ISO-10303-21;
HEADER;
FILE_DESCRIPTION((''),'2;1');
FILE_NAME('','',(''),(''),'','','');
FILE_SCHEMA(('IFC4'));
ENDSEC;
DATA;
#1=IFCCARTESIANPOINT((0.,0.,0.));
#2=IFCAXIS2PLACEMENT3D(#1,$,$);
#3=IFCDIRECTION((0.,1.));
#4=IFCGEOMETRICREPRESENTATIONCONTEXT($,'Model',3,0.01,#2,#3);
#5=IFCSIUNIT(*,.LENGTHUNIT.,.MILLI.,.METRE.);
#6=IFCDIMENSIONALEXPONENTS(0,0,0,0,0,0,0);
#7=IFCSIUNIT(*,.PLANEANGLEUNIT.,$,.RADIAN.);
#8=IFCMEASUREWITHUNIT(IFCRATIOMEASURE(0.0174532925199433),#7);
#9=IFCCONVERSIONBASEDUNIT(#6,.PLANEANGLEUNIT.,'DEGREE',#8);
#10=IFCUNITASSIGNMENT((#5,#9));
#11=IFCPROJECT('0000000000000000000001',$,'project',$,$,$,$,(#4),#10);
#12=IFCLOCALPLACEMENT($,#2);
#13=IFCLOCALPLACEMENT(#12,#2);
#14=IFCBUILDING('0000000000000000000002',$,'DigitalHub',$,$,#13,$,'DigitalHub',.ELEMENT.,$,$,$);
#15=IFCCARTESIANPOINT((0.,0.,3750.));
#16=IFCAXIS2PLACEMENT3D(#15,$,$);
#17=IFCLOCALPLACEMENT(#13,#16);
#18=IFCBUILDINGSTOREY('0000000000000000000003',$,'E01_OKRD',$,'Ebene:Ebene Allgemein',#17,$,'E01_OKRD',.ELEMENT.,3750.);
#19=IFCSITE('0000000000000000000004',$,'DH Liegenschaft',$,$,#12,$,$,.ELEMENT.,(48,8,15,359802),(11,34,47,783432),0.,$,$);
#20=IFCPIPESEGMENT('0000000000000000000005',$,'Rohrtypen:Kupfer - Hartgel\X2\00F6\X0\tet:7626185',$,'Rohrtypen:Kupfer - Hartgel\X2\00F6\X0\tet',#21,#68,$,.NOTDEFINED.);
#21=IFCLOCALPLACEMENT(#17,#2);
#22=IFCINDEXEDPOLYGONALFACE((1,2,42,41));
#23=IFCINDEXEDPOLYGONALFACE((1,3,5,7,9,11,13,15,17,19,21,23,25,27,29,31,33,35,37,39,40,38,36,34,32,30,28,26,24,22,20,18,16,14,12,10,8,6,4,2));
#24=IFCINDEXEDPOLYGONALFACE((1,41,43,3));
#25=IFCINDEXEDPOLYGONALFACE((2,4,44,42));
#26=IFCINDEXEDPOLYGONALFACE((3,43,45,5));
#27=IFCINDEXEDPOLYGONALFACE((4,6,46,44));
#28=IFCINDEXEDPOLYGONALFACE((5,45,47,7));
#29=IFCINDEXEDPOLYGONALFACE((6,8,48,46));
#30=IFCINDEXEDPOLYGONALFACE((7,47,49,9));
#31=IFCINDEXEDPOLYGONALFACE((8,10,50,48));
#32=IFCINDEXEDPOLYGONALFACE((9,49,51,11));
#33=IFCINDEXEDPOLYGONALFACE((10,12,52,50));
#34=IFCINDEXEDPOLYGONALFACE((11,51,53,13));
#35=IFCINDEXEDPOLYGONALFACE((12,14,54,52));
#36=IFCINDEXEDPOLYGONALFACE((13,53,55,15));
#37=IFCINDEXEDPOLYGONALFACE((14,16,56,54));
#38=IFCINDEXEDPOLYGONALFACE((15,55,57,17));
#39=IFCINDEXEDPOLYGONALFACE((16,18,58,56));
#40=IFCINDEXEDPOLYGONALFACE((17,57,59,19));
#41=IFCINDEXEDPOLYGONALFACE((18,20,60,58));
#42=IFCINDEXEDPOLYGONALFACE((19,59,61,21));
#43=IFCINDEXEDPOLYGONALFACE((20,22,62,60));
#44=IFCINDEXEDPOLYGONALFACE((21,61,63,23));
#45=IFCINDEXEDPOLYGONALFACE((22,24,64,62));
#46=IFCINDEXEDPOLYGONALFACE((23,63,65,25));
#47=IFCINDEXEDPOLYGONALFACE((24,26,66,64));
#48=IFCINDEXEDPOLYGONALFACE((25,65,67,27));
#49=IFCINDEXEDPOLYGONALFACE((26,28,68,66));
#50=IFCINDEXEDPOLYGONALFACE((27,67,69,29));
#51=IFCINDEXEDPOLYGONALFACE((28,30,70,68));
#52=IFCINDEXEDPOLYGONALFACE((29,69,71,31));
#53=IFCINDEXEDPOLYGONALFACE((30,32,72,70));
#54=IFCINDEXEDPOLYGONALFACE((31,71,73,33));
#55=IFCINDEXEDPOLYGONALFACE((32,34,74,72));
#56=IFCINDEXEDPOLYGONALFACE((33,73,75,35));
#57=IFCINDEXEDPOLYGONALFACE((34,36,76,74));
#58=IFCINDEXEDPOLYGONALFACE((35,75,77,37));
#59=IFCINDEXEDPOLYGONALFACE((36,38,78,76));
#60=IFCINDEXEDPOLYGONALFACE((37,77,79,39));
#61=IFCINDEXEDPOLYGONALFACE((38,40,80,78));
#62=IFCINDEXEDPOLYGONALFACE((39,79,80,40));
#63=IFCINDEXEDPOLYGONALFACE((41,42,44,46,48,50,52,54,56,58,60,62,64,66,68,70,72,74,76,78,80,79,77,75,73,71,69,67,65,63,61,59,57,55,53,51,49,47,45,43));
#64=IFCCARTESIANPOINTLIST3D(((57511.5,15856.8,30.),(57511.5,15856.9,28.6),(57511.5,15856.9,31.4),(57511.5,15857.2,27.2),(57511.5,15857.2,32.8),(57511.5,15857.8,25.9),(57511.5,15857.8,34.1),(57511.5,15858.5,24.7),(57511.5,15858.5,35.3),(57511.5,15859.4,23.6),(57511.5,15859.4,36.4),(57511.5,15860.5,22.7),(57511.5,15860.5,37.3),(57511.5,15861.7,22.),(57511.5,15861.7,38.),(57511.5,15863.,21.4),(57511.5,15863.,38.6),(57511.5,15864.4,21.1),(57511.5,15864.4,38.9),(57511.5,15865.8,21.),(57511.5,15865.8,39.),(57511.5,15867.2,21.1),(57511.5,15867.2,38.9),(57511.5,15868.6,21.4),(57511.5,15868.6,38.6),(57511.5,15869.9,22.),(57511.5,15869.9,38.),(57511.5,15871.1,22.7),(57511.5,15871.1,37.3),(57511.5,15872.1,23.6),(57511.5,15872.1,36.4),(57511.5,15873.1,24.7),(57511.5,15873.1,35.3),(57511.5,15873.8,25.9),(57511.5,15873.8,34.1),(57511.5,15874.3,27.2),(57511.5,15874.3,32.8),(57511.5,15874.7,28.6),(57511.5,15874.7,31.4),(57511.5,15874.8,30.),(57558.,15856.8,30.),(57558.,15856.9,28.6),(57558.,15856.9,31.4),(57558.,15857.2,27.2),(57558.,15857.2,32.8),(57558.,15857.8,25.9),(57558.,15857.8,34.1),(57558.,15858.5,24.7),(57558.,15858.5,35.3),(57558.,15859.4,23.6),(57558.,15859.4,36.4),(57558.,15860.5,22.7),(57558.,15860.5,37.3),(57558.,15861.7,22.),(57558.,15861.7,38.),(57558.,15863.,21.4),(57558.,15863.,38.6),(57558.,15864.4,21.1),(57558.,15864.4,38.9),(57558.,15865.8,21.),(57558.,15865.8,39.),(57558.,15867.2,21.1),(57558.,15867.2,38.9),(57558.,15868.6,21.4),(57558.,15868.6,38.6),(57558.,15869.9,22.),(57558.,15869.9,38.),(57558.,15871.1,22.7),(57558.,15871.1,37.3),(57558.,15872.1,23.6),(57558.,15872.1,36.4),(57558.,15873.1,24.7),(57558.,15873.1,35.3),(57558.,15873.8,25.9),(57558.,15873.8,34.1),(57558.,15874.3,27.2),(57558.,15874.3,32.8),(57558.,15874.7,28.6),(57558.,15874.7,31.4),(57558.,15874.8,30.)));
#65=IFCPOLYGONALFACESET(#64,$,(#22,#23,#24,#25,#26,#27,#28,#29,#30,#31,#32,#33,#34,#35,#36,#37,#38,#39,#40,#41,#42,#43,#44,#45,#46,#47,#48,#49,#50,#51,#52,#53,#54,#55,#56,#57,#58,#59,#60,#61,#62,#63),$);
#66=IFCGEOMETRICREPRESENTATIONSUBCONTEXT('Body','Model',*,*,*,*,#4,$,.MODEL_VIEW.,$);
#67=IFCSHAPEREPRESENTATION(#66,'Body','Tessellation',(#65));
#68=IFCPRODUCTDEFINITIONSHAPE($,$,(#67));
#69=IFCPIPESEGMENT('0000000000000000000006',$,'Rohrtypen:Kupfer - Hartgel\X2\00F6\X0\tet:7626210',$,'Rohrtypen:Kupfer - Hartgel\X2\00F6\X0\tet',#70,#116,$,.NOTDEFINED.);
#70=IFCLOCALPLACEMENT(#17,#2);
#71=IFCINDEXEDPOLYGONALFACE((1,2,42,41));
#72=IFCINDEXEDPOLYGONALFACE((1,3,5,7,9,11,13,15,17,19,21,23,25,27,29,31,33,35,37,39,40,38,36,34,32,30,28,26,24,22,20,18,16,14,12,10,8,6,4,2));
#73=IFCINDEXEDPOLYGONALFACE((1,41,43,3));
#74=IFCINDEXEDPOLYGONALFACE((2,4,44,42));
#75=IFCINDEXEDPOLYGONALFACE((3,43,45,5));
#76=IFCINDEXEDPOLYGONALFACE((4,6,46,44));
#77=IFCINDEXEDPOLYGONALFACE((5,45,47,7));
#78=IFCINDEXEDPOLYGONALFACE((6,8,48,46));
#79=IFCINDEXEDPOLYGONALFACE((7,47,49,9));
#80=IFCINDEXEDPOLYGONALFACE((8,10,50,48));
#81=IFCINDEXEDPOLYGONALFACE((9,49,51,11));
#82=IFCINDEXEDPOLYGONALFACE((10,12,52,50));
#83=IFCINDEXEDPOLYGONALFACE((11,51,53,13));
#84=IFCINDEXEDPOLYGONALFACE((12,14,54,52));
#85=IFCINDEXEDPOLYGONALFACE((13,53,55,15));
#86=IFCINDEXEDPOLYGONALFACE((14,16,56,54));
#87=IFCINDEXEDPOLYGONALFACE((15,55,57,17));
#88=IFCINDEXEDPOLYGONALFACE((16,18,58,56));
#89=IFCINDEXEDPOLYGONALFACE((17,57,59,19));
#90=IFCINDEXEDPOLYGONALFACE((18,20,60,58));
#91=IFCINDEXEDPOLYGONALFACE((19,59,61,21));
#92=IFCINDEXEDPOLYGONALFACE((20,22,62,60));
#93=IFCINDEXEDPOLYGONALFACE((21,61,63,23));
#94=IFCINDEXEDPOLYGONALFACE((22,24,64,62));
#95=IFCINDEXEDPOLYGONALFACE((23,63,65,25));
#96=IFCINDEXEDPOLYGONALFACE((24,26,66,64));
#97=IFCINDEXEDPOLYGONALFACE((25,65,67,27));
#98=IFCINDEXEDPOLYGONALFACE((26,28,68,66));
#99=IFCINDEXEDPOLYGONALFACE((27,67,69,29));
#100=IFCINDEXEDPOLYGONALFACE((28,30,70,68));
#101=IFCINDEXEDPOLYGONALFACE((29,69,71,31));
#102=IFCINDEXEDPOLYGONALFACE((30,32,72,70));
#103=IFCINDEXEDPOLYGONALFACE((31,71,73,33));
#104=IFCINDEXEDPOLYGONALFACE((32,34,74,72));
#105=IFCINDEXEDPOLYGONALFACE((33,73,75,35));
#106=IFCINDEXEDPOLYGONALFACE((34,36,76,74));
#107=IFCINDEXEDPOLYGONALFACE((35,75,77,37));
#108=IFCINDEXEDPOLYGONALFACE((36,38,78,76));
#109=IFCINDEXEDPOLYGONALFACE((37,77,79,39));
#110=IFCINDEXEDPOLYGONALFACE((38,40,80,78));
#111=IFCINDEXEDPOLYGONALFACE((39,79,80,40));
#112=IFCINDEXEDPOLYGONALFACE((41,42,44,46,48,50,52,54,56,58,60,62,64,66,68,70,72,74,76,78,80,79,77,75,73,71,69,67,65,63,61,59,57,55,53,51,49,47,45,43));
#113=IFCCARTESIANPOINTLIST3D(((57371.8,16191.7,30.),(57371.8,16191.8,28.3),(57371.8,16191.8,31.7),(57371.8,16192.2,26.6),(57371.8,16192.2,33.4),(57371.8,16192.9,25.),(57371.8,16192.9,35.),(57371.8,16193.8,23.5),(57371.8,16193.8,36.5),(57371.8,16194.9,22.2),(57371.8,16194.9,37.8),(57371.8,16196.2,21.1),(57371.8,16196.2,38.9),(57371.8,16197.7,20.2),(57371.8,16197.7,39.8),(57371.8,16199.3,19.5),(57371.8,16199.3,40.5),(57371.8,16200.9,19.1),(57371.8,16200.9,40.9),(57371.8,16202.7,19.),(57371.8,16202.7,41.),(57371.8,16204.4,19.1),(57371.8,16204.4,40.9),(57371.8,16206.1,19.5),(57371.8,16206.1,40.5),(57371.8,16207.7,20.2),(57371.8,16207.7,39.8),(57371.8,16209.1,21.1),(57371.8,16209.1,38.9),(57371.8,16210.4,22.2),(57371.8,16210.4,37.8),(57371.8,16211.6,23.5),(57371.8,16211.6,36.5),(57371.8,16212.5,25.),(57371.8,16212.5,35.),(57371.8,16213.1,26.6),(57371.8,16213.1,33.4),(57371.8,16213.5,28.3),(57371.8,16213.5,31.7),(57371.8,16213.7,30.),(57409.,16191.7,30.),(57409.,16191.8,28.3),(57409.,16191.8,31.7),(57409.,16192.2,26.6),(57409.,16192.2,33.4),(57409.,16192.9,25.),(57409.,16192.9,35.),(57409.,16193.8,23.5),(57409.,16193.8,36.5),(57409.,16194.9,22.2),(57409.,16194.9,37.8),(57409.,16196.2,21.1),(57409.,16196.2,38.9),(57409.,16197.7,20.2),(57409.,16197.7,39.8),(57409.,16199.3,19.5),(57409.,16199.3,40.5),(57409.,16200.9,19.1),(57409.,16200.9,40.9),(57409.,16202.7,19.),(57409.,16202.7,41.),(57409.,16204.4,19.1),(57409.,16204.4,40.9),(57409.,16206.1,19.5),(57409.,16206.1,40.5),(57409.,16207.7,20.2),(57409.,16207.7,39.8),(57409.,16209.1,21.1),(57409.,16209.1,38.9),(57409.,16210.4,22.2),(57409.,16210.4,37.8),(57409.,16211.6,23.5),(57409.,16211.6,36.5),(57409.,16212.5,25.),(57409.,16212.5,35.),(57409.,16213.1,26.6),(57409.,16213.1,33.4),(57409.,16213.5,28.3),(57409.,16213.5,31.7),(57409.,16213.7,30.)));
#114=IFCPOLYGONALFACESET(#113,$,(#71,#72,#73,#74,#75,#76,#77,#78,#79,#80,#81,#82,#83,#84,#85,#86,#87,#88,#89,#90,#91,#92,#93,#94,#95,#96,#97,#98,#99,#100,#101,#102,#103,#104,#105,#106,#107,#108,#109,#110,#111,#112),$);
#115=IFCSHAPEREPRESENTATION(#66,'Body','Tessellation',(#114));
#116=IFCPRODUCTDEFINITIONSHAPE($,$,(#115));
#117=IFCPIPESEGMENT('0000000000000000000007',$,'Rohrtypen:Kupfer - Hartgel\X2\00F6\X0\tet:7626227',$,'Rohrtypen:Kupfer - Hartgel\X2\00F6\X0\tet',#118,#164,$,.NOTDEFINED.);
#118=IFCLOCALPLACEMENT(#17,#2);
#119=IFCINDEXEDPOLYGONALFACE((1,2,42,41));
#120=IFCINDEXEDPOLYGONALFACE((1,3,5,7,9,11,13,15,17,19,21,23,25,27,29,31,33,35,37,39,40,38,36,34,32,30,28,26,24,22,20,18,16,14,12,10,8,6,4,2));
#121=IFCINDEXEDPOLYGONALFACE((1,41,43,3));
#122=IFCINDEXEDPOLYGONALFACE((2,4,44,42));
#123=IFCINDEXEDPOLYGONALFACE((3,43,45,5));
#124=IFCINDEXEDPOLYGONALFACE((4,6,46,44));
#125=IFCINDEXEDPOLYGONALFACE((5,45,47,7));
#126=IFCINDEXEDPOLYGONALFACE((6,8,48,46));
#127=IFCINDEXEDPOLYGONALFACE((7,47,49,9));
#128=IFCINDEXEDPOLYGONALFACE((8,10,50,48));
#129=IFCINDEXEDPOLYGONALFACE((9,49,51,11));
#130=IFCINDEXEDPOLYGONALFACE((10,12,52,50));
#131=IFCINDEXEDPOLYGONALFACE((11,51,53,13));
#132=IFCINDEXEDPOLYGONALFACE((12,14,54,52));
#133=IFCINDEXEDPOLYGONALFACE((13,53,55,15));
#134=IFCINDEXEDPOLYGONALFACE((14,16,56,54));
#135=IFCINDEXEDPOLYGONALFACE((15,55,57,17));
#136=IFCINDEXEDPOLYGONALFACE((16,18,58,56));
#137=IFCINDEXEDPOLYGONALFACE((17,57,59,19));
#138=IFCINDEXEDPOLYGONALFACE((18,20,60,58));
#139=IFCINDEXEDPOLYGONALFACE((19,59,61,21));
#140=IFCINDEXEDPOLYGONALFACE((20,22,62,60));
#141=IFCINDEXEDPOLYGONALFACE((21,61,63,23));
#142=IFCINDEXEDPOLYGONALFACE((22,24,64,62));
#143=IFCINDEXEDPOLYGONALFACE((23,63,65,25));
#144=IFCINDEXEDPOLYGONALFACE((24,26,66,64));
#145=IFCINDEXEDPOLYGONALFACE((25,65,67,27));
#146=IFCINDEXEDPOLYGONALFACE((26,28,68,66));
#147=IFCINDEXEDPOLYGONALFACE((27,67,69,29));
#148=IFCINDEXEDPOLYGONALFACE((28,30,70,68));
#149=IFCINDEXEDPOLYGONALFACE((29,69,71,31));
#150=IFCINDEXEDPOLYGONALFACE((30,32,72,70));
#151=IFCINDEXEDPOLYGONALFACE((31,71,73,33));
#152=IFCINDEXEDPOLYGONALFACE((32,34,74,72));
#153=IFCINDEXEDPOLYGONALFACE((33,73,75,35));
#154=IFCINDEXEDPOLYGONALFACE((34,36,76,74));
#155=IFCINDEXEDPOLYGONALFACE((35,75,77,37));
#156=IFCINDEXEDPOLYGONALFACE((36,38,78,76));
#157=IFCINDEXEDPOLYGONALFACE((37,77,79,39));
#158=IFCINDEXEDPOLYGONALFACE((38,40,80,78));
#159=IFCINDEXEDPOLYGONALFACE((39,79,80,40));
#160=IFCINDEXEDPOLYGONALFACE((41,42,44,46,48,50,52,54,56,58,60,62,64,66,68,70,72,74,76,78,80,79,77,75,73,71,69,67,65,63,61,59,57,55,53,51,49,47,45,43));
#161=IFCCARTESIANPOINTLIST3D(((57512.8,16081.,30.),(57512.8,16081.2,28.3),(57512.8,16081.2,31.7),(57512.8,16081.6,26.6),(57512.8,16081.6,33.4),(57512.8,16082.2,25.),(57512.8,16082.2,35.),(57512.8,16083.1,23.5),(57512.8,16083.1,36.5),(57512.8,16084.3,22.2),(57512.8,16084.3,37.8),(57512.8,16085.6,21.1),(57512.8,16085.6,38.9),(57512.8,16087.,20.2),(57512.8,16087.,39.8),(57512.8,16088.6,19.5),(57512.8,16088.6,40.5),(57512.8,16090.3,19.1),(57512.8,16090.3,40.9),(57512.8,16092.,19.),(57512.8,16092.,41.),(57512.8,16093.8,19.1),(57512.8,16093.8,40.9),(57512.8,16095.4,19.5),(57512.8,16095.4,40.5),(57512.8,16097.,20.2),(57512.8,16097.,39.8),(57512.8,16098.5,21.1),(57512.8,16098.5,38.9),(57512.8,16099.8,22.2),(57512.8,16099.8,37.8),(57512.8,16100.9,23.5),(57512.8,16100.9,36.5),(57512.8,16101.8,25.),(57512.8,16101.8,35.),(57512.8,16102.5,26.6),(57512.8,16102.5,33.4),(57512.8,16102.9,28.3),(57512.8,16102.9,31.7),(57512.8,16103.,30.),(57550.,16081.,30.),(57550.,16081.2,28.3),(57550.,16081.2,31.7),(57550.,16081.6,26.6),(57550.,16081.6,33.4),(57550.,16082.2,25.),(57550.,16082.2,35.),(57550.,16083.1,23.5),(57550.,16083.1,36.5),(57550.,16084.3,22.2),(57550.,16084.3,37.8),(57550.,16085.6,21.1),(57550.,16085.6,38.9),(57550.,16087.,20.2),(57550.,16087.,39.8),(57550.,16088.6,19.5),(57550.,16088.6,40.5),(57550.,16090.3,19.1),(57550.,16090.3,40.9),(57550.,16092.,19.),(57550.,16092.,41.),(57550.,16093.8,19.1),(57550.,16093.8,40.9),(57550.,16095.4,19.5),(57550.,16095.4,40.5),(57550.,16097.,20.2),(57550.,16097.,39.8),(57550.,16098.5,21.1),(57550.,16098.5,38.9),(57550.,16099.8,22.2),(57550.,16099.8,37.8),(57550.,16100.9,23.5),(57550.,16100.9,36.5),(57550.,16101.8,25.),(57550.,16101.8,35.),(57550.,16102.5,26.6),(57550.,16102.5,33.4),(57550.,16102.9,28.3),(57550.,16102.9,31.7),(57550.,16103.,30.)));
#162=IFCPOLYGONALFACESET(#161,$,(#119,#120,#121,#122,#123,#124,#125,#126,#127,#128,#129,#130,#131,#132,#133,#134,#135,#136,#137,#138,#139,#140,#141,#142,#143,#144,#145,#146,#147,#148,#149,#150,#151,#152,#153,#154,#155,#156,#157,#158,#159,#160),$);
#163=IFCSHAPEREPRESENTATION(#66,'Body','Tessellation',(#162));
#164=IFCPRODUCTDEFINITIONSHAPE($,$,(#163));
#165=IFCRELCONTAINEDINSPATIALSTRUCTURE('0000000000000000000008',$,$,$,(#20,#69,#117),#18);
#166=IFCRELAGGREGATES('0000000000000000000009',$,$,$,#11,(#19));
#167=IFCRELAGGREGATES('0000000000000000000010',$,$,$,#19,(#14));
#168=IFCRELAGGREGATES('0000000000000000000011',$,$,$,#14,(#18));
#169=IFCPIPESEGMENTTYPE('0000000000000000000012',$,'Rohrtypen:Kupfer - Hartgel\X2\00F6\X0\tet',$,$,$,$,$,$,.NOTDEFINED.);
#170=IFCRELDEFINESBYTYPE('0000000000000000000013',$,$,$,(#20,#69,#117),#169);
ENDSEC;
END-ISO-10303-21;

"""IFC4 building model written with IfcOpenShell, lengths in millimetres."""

from ifc_helpers import new_model, entity, si_unit, converted_unit, direction, frame, origin, place, context, subcontext, project, spatial, indexed_curve, outline, extrude, type_object, element, save


model = new_model("IFC4")

# Units and contexts
model_context = context("Model", 3, precision=0.01, world=origin(), true_north=direction((0.0, 1.0)))
body_context = subcontext(model_context, "Body", "Model", "MODEL_VIEW")
ifc_project = project(units=[si_unit("LENGTHUNIT", "METRE", prefix="MILLI"), converted_unit("PLANEANGLEUNIT", "DEGREE", entity("IfcRatioMeasure", 0.0174532925199433), si_unit("PLANEANGLEUNIT", "RADIAN"), dimensions=[0, 0, 0, 0, 0, 0, 0])], contexts=[model_context])

# Site, building, storey
site_placement = place(None, origin())
site = spatial("IfcSite", under=ifc_project, at=site_placement, Name="DH Liegenschaft", CompositionType="ELEMENT", RefLatitude=(48, 8, 15, 359802), RefLongitude=(11, 34, 47, 783432), RefElevation=0.0)
building_placement = place(site_placement, origin())
building = spatial("IfcBuilding", under=site, at=building_placement, Name="DigitalHub", LongName="DigitalHub", CompositionType="ELEMENT")
storey_placement = place(building_placement, frame((0.0, 0.0, 3750.0)))
storey = spatial("IfcBuildingStorey", under=building, at=storey_placement, Name="E01_OKRD", ObjectType="Ebene:Ebene Allgemein", LongName="E01_OKRD", CompositionType="ELEMENT", Elevation=3750.0)

# Pipe segments
pipe_segment_type = type_object("IfcPipeSegmentType", Name="Rohrtypen:Kupfer - Hartgelötet", PredefinedType="NOTDEFINED")
pipe_segment_1_placement = place(storey_placement, frame((57511.5, 15855.2, 19.4)))
element("IfcPipeSegment", 1, at=pipe_segment_1_placement, inside=storey, type_object=pipe_segment_type, Name="Rohrtypen:Kupfer - Hartgelötet:7626185", ObjectType="Rohrtypen:Kupfer - Hartgelötet", PredefinedType="NOTDEFINED", context=body_context, shape_type="SweptSolid", body=[
    extrude(outline(indexed_curve([(9.0, 0.0), (8.9, 1.4), (8.6, 2.8), (8.0, 4.1), (7.3, 5.3), (6.4, 6.4), (5.3, 7.3), (4.1, 8.0), (2.8, 8.6), (1.4, 8.9), (0.0, 9.0), (-1.4, 8.9), (-2.8, 8.6), (-4.1, 8.0), (-5.3, 7.3), (-6.4, 6.4), (-7.3, 5.3), (-8.0, 4.1), (-8.6, 2.8), (-8.9, 1.4), (-9.0, 0.0), (-8.9, -1.4), (-8.6, -2.8), (-8.0, -4.1), (-7.3, -5.3), (-6.4, -6.4), (-5.3, -7.3), (-4.1, -8.0), (-2.8, -8.6), (-1.4, -8.9), (0.0, -9.0), (1.4, -8.9), (2.8, -8.6), (4.1, -8.0), (5.3, -7.3), (6.4, -6.4), (7.3, -5.3), (8.0, -4.1), (8.6, -2.8), (8.9, -1.4), (9.0, 0.0)], self_intersect=False)), frame((0.0, 10.6, 10.6), z_axis=(1.0, 0.0, 0.0), x_axis=(0.0, 1.0, 0.0)), (0.0, 0.0, 1.0), 46.4),
])
pipe_segment_2_placement = place(storey_placement, frame((57371.8, 16190.1, 17.4)))
element("IfcPipeSegment", 2, at=pipe_segment_2_placement, inside=storey, type_object=pipe_segment_type, Name="Rohrtypen:Kupfer - Hartgelötet:7626210", ObjectType="Rohrtypen:Kupfer - Hartgelötet", PredefinedType="NOTDEFINED", context=body_context, shape_type="SweptSolid", body=[
    extrude(outline(indexed_curve([(11.0, 0.0), (10.9, 1.7), (10.5, 3.4), (9.8, 5.0), (8.9, 6.5), (7.8, 7.8), (6.5, 8.9), (5.0, 9.8), (3.4, 10.5), (1.7, 10.9), (0.0, 11.0), (-1.7, 10.9), (-3.4, 10.5), (-5.0, 9.8), (-6.5, 8.9), (-7.8, 7.8), (-8.9, 6.5), (-9.8, 5.0), (-10.5, 3.4), (-10.9, 1.7), (-11.0, 0.0), (-10.9, -1.7), (-10.5, -3.4), (-9.8, -5.0), (-8.9, -6.5), (-7.8, -7.8), (-6.5, -8.9), (-5.0, -9.8), (-3.4, -10.5), (-1.7, -10.9), (0.0, -11.0), (1.7, -10.9), (3.4, -10.5), (5.0, -9.8), (6.5, -8.9), (7.8, -7.8), (8.9, -6.5), (9.8, -5.0), (10.5, -3.4), (10.9, -1.7), (11.0, 0.0)], self_intersect=False)), frame((0.0, 12.6, 12.6), z_axis=(1.0, 0.0, 0.0), x_axis=(0.0, 1.0, 0.0)), (0.0, 0.0, 1.0), 37.1),
])
pipe_segment_3_placement = place(storey_placement, frame((57512.8, 16079.4, 17.4)))
element("IfcPipeSegment", 3, at=pipe_segment_3_placement, inside=storey, type_object=pipe_segment_type, Name="Rohrtypen:Kupfer - Hartgelötet:7626227", ObjectType="Rohrtypen:Kupfer - Hartgelötet", PredefinedType="NOTDEFINED", context=body_context, shape_type="SweptSolid", body=[
    extrude(outline(indexed_curve([(11.0, 0.0), (10.9, 1.7), (10.5, 3.4), (9.8, 5.0), (8.9, 6.5), (7.8, 7.8), (6.5, 8.9), (5.0, 9.8), (3.4, 10.5), (1.7, 10.9), (0.0, 11.0), (-1.7, 10.9), (-3.4, 10.5), (-5.0, 9.8), (-6.5, 8.9), (-7.8, 7.8), (-8.9, 6.5), (-9.8, 5.0), (-10.5, 3.4), (-10.9, 1.7), (-11.0, 0.0), (-10.9, -1.7), (-10.5, -3.4), (-9.8, -5.0), (-8.9, -6.5), (-7.8, -7.8), (-6.5, -8.9), (-5.0, -9.8), (-3.4, -10.5), (-1.7, -10.9), (0.0, -11.0), (1.7, -10.9), (3.4, -10.5), (5.0, -9.8), (6.5, -8.9), (7.8, -7.8), (8.9, -6.5), (9.8, -5.0), (10.5, -3.4), (10.9, -1.7), (11.0, 0.0)], self_intersect=False)), frame((0.0, 12.6, 12.6), z_axis=(1.0, 0.0, 0.0), x_axis=(0.0, 1.0, 0.0)), (0.0, 0.0, 1.0), 37.1),
])

save(model, "model.ifc")
